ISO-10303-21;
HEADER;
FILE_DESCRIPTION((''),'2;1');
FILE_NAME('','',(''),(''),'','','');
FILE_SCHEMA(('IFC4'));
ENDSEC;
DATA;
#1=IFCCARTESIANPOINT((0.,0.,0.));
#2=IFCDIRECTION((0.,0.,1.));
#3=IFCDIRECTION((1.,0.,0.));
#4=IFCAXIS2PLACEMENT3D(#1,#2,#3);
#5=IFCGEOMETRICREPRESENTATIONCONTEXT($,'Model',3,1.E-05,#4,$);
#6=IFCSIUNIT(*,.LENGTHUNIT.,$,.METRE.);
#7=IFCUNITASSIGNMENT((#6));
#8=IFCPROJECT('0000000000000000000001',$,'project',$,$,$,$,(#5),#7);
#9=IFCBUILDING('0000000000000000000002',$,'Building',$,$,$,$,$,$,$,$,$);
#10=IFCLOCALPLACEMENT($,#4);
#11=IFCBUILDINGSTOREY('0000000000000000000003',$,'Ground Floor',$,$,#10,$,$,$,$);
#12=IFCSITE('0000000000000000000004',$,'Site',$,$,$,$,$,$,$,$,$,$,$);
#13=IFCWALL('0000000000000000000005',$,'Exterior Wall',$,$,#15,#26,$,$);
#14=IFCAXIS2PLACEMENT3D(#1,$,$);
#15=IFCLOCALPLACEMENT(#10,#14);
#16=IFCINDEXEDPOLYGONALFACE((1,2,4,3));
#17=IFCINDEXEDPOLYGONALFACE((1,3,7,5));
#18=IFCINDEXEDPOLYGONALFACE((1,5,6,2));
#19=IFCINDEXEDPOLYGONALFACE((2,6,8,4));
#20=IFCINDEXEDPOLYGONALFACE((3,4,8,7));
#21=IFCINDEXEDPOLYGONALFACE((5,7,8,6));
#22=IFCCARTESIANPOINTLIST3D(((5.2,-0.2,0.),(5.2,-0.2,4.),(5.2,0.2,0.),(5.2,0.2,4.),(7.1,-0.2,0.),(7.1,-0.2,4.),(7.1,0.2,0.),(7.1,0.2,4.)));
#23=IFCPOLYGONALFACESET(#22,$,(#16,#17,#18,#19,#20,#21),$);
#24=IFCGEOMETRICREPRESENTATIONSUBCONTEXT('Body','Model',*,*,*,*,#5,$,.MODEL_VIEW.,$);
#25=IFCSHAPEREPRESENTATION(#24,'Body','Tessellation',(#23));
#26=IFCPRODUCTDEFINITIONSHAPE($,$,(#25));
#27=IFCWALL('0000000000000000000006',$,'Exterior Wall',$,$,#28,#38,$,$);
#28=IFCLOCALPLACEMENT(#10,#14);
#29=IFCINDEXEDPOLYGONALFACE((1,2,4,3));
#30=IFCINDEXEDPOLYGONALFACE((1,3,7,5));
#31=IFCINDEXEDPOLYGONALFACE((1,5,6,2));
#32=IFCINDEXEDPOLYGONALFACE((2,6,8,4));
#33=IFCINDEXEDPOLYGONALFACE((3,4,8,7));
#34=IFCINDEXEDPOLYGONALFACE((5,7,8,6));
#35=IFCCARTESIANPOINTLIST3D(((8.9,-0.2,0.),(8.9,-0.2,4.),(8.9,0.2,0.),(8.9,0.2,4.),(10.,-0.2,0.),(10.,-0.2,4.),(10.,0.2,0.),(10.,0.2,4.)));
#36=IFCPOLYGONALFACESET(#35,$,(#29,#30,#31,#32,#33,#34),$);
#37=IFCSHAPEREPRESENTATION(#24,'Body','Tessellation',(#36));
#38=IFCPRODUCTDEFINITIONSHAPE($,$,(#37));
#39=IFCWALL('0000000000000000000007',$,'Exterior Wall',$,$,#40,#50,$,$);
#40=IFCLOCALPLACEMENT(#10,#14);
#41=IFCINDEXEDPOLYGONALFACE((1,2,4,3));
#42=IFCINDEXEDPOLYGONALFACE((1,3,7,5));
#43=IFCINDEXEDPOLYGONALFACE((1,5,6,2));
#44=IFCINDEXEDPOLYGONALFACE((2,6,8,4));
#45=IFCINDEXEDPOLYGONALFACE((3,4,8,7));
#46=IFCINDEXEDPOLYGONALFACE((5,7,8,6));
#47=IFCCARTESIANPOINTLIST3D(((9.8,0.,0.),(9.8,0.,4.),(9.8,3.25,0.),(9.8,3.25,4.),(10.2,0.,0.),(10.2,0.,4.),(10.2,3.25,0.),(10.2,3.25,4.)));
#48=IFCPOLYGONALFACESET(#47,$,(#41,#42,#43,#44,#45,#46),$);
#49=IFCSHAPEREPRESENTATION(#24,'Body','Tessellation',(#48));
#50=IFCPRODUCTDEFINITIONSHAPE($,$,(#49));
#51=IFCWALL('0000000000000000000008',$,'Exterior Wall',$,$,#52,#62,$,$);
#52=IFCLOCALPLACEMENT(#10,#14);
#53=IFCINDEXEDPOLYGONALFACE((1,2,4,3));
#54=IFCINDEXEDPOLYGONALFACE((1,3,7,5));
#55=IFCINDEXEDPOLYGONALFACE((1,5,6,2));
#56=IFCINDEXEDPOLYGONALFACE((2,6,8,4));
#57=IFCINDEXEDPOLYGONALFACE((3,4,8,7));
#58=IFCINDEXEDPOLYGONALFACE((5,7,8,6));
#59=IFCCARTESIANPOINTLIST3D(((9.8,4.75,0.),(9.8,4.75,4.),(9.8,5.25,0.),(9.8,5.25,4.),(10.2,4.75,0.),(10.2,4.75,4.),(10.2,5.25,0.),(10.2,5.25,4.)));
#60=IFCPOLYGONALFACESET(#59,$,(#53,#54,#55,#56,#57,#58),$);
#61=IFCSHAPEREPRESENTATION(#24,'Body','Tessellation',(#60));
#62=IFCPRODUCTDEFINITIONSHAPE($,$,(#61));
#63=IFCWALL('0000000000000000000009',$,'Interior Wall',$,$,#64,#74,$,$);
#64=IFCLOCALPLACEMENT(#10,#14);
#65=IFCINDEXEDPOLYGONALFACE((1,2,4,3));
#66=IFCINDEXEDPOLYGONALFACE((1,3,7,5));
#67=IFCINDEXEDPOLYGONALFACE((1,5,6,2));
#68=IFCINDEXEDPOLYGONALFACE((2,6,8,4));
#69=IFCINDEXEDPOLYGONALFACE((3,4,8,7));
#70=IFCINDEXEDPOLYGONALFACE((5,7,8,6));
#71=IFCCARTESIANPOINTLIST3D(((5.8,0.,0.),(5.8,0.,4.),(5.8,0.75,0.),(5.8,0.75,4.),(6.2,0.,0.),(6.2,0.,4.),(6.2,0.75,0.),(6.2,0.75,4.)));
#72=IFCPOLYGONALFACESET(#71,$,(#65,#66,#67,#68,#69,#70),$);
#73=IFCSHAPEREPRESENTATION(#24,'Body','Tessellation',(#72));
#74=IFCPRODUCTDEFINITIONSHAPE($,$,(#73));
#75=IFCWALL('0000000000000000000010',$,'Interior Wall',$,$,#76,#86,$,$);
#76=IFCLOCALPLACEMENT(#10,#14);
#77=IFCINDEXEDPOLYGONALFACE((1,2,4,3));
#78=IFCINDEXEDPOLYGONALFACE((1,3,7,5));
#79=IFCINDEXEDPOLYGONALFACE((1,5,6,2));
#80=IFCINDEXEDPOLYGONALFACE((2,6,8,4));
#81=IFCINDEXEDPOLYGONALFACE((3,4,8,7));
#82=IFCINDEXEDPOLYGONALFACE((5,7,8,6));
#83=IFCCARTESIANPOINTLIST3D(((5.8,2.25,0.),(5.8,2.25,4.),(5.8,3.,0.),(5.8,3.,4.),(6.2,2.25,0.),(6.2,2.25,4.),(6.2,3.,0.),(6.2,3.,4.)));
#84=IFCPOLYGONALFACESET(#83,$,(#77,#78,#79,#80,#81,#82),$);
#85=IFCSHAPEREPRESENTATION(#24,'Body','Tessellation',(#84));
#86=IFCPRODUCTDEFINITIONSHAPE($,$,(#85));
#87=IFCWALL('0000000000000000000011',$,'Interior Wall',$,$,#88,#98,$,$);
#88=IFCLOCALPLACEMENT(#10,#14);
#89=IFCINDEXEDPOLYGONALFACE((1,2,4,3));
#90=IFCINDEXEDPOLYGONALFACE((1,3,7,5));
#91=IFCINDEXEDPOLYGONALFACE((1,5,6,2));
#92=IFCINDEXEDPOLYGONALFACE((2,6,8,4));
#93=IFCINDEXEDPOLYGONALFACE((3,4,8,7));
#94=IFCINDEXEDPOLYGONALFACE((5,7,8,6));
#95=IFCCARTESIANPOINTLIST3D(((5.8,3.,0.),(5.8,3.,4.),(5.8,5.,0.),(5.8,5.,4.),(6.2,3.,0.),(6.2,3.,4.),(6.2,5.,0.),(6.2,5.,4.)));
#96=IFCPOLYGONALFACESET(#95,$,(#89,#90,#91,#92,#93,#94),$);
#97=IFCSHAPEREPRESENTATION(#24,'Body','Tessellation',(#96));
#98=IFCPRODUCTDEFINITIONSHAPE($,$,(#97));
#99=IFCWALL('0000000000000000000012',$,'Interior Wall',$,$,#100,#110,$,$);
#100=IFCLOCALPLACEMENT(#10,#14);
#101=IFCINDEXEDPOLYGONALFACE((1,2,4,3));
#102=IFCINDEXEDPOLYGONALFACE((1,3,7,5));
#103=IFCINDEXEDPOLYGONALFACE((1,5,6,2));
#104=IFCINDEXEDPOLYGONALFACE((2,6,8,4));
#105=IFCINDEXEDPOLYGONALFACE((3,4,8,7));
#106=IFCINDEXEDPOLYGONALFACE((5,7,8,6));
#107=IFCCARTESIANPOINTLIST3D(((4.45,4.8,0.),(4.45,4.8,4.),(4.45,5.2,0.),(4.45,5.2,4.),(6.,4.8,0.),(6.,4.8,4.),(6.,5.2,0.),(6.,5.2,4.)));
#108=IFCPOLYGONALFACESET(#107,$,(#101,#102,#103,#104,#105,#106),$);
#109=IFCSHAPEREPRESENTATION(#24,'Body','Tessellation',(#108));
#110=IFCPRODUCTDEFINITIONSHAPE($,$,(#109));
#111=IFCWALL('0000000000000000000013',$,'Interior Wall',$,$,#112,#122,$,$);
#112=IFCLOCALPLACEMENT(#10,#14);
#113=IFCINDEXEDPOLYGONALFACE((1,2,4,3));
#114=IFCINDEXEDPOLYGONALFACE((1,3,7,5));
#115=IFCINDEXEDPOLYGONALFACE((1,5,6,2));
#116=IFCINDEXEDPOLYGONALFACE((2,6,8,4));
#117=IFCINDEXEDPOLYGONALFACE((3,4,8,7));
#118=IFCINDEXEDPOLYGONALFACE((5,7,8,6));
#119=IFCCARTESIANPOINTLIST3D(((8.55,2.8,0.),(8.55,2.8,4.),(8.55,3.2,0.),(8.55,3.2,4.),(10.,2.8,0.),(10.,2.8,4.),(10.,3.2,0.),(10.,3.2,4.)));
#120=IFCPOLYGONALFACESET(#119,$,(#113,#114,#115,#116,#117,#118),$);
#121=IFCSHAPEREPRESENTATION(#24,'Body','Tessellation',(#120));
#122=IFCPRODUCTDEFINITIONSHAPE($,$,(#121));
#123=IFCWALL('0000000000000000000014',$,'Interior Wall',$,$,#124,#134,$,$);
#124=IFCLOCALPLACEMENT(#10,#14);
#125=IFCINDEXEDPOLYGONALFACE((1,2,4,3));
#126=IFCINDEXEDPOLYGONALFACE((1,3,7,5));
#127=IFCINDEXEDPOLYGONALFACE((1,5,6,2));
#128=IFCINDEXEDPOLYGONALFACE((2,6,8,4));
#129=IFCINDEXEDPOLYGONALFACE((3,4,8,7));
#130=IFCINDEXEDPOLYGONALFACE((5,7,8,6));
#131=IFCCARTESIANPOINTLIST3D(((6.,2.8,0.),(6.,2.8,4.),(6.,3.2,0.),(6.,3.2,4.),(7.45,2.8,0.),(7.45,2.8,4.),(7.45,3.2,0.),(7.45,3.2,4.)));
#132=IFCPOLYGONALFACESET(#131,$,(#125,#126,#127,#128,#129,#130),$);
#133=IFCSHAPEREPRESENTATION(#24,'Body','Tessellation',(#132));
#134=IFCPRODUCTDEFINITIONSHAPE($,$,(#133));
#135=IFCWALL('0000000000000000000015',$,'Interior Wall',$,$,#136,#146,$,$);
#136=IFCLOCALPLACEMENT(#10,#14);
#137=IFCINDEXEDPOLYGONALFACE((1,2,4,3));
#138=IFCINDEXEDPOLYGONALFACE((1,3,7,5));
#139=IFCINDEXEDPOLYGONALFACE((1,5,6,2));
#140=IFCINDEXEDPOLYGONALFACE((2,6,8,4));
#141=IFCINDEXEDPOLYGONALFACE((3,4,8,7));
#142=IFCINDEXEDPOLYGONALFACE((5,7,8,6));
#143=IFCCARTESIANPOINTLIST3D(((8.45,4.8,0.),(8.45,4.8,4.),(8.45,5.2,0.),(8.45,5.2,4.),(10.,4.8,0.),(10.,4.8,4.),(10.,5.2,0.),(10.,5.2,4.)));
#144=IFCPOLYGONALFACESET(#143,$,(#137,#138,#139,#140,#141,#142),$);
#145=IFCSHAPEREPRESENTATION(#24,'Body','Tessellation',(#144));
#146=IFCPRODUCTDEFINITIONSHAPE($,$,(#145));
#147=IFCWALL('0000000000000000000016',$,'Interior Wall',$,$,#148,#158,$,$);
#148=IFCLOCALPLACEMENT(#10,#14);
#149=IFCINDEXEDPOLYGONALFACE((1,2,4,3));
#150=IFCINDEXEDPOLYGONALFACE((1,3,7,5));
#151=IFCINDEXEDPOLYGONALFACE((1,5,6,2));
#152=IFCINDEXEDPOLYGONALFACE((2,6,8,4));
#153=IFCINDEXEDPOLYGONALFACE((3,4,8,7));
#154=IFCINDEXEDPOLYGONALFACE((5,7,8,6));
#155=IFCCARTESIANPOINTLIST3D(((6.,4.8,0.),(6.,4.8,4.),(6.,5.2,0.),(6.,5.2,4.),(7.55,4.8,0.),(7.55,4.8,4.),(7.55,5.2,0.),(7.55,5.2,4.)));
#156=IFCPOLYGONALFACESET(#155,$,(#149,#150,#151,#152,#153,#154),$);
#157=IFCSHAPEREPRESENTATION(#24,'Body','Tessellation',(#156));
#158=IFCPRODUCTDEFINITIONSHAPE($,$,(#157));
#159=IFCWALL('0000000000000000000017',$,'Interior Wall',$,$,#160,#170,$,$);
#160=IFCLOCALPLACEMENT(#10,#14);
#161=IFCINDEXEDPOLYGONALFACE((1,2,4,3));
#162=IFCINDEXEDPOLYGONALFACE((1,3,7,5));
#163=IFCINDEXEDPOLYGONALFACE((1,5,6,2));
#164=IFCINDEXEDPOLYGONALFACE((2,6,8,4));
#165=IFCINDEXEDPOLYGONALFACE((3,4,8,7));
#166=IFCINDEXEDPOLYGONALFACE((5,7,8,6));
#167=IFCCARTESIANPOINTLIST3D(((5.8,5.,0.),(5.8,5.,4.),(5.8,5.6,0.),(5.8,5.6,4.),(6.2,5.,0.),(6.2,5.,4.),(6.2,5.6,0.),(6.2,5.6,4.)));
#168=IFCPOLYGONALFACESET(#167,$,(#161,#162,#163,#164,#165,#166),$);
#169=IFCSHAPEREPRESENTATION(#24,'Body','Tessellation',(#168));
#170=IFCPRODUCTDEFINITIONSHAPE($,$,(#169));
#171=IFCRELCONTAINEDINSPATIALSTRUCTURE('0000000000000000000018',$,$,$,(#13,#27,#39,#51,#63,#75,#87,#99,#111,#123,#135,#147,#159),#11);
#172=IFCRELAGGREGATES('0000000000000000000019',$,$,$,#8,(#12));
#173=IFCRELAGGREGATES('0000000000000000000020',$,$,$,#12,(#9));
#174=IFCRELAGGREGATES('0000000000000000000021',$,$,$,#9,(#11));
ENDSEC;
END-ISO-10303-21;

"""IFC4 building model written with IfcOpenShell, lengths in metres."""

from ifc_helpers import new_model, si_unit, frame, origin_with_axes, place, context, subcontext, project, spatial, indexed_curve, outline, extrude, element, save


model = new_model("IFC4")

# Units and contexts
model_context = context("Model", 3, precision=1e-05, world=origin_with_axes())
body_context = subcontext(model_context, "Body", "Model", "MODEL_VIEW")
ifc_project = project(units=[si_unit("LENGTHUNIT", "METRE")], contexts=[model_context])

# Site, building, storey
site = spatial("IfcSite", under=ifc_project, Name="Site")
building = spatial("IfcBuilding", under=site, Name="Building")
storey_placement = place(None, origin_with_axes())
storey = spatial("IfcBuildingStorey", under=building, at=storey_placement, Name="Ground Floor")

# Walls
wall_1_placement = place(storey_placement, frame((5.2, 0.0, 0.0), z_axis=(0.0, 0.0, 1.0), x_axis=(1.0, 0.0, 0.0)))
element("IfcWall", 1, at=wall_1_placement, inside=storey, Name="Exterior Wall", context=body_context, shape_type="SweptSolid", body=[
    extrude(outline(indexed_curve([(0.0, 0.0), (0.0, 0.4), (1.9, 0.4), (1.9, 0.0), (0.0, 0.0)], self_intersect=False)), frame((0.0, -0.2, 0.0), z_axis=(0.0, 0.0, 1.0), x_axis=(1.0, 0.0, 0.0)), (0.0, 0.0, 1.0), 4.0),
])
wall_2_placement = place(storey_placement, frame((8.9, 0.0, 0.0), z_axis=(0.0, 0.0, 1.0), x_axis=(1.0, 0.0, 0.0)))
element("IfcWall", 2, at=wall_2_placement, inside=storey, Name="Exterior Wall", context=body_context, shape_type="SweptSolid", body=[
    extrude(outline(indexed_curve([(0.0, 0.0), (0.0, 0.4), (1.1, 0.4), (1.1, 0.0), (0.0, 0.0)], self_intersect=False)), frame((0.0, -0.2, 0.0), z_axis=(0.0, 0.0, 1.0), x_axis=(1.0, 0.0, 0.0)), (0.0, 0.0, 1.0), 4.0),
])
wall_3_placement = place(storey_placement, frame((10.0, 0.0, 0.0), z_axis=(0.0, 0.0, 1.0), x_axis=(0.0, 1.0, 0.0)))
element("IfcWall", 3, at=wall_3_placement, inside=storey, Name="Exterior Wall", context=body_context, shape_type="SweptSolid", body=[
    extrude(outline(indexed_curve([(0.0, 0.0), (0.0, 0.4), (3.25, 0.4), (3.25, 0.0), (0.0, 0.0)], self_intersect=False)), frame((0.0, -0.2, 0.0), z_axis=(0.0, 0.0, 1.0), x_axis=(1.0, 0.0, 0.0)), (0.0, 0.0, 1.0), 4.0),
])
wall_4_placement = place(storey_placement, frame((10.0, 4.75, 0.0), z_axis=(0.0, 0.0, 1.0), x_axis=(0.0, 1.0, 0.0)))
element("IfcWall", 4, at=wall_4_placement, inside=storey, Name="Exterior Wall", context=body_context, shape_type="SweptSolid", body=[
    extrude(outline(indexed_curve([(0.0, 0.0), (0.0, 0.4), (0.5, 0.4), (0.5, 0.0), (0.0, 0.0)], self_intersect=False)), frame((0.0, -0.2, 0.0), z_axis=(0.0, 0.0, 1.0), x_axis=(1.0, 0.0, 0.0)), (0.0, 0.0, 1.0), 4.0),
])
for number, where, z_axis, x_axis, name in (
    (5, (6.0, 0.0, 0.0), (0.0, 0.0, 1.0), (0.0, 1.0, 0.0), "Interior Wall"),
    (6, (6.0, 2.25, 0.0), (0.0, 0.0, 1.0), (0.0, 1.0, 0.0), "Interior Wall"),
):
    element("IfcWall", number, at=place(storey_placement, frame(where, z_axis=z_axis, x_axis=x_axis)), inside=storey, Name=name, context=body_context, shape_type="SweptSolid", body=[
        extrude(outline(indexed_curve([(0.0, 0.0), (0.0, 0.4), (0.75, 0.4), (0.75, 0.0), (0.0, 0.0)], self_intersect=False)), frame((0.0, -0.2, 0.0), z_axis=(0.0, 0.0, 1.0), x_axis=(1.0, 0.0, 0.0)), (0.0, 0.0, 1.0), 4.0),
    ])
wall_5_placement = place(storey_placement, frame((6.0, 3.0, 0.0), z_axis=(0.0, 0.0, 1.0), x_axis=(0.0, 1.0, 0.0)))
element("IfcWall", 7, at=wall_5_placement, inside=storey, Name="Interior Wall", context=body_context, shape_type="SweptSolid", body=[
    extrude(outline(indexed_curve([(0.0, 0.0), (0.0, 0.4), (2.0, 0.4), (2.0, 0.0), (0.0, 0.0)], self_intersect=False)), frame((0.0, -0.2, 0.0), z_axis=(0.0, 0.0, 1.0), x_axis=(1.0, 0.0, 0.0)), (0.0, 0.0, 1.0), 4.0),
])
wall_6_placement = place(storey_placement, frame((6.0, 5.0, 0.0), z_axis=(0.0, 0.0, 1.0), x_axis=(-1.0, 0.0, 0.0)))
element("IfcWall", 8, at=wall_6_placement, inside=storey, Name="Interior Wall", context=body_context, shape_type="SweptSolid", body=[
    extrude(outline(indexed_curve([(0.0, 0.0), (0.0, 0.4), (1.55, 0.4), (1.55, 0.0), (0.0, 0.0)], self_intersect=False)), frame((0.0, -0.2, 0.0), z_axis=(0.0, 0.0, 1.0), x_axis=(1.0, 0.0, 0.0)), (0.0, 0.0, 1.0), 4.0),
])
wall_7_placement = place(storey_placement, frame((10.0, 3.0, 0.0), z_axis=(0.0, 0.0, 1.0), x_axis=(-1.0, 0.0, 0.0)))
element("IfcWall", 9, at=wall_7_placement, inside=storey, Name="Interior Wall", context=body_context, shape_type="SweptSolid", body=[
    extrude(outline(indexed_curve([(0.0, 0.0), (0.0, 0.4), (1.45, 0.4), (1.45, 0.0), (0.0, 0.0)], self_intersect=False)), frame((0.0, -0.2, 0.0), z_axis=(0.0, 0.0, 1.0), x_axis=(1.0, 0.0, 0.0)), (0.0, 0.0, 1.0), 4.0),
])
wall_8_placement = place(storey_placement, frame((7.45, 3.0, 0.0), z_axis=(0.0, 0.0, 1.0), x_axis=(-1.0, 0.0, 0.0)))
element("IfcWall", 10, at=wall_8_placement, inside=storey, Name="Interior Wall", context=body_context, shape_type="SweptSolid", body=[
    extrude(outline(indexed_curve([(0.0, 0.0), (0.0, 0.4), (1.45, 0.4), (1.45, 0.0), (0.0, 0.0)], self_intersect=False)), frame((0.0, -0.2, 0.0), z_axis=(0.0, 0.0, 1.0), x_axis=(1.0, 0.0, 0.0)), (0.0, 0.0, 1.0), 4.0),
])
wall_9_placement = place(storey_placement, frame((10.0, 5.0, 0.0), z_axis=(0.0, 0.0, 1.0), x_axis=(-1.0, 0.0, 0.0)))
element("IfcWall", 11, at=wall_9_placement, inside=storey, Name="Interior Wall", context=body_context, shape_type="SweptSolid", body=[
    extrude(outline(indexed_curve([(0.0, 0.0), (0.0, 0.4), (1.55, 0.4), (1.55, 0.0), (0.0, 0.0)], self_intersect=False)), frame((0.0, -0.2, 0.0), z_axis=(0.0, 0.0, 1.0), x_axis=(1.0, 0.0, 0.0)), (0.0, 0.0, 1.0), 4.0),
])
wall_10_placement = place(storey_placement, frame((7.55, 5.0, 0.0), z_axis=(0.0, 0.0, 1.0), x_axis=(-1.0, 0.0, 0.0)))
element("IfcWall", 12, at=wall_10_placement, inside=storey, Name="Interior Wall", context=body_context, shape_type="SweptSolid", body=[
    extrude(outline(indexed_curve([(0.0, 0.0), (0.0, 0.4), (1.55, 0.4), (1.55, 0.0), (0.0, 0.0)], self_intersect=False)), frame((0.0, -0.2, 0.0), z_axis=(0.0, 0.0, 1.0), x_axis=(1.0, 0.0, 0.0)), (0.0, 0.0, 1.0), 4.0),
])
wall_11_placement = place(storey_placement, frame((6.0, 5.0, 0.0), z_axis=(0.0, 0.0, 1.0), x_axis=(0.0, 1.0, 0.0)))
element("IfcWall", 13, at=wall_11_placement, inside=storey, Name="Interior Wall", context=body_context, shape_type="SweptSolid", body=[
    extrude(outline(indexed_curve([(0.0, 0.0), (0.0, 0.4), (0.6, 0.4), (0.6, 0.0), (0.0, 0.0)], self_intersect=False)), frame((0.0, -0.2, 0.0), z_axis=(0.0, 0.0, 1.0), x_axis=(1.0, 0.0, 0.0)), (0.0, 0.0, 1.0), 4.0),
])

save(model, "model.ifc")
